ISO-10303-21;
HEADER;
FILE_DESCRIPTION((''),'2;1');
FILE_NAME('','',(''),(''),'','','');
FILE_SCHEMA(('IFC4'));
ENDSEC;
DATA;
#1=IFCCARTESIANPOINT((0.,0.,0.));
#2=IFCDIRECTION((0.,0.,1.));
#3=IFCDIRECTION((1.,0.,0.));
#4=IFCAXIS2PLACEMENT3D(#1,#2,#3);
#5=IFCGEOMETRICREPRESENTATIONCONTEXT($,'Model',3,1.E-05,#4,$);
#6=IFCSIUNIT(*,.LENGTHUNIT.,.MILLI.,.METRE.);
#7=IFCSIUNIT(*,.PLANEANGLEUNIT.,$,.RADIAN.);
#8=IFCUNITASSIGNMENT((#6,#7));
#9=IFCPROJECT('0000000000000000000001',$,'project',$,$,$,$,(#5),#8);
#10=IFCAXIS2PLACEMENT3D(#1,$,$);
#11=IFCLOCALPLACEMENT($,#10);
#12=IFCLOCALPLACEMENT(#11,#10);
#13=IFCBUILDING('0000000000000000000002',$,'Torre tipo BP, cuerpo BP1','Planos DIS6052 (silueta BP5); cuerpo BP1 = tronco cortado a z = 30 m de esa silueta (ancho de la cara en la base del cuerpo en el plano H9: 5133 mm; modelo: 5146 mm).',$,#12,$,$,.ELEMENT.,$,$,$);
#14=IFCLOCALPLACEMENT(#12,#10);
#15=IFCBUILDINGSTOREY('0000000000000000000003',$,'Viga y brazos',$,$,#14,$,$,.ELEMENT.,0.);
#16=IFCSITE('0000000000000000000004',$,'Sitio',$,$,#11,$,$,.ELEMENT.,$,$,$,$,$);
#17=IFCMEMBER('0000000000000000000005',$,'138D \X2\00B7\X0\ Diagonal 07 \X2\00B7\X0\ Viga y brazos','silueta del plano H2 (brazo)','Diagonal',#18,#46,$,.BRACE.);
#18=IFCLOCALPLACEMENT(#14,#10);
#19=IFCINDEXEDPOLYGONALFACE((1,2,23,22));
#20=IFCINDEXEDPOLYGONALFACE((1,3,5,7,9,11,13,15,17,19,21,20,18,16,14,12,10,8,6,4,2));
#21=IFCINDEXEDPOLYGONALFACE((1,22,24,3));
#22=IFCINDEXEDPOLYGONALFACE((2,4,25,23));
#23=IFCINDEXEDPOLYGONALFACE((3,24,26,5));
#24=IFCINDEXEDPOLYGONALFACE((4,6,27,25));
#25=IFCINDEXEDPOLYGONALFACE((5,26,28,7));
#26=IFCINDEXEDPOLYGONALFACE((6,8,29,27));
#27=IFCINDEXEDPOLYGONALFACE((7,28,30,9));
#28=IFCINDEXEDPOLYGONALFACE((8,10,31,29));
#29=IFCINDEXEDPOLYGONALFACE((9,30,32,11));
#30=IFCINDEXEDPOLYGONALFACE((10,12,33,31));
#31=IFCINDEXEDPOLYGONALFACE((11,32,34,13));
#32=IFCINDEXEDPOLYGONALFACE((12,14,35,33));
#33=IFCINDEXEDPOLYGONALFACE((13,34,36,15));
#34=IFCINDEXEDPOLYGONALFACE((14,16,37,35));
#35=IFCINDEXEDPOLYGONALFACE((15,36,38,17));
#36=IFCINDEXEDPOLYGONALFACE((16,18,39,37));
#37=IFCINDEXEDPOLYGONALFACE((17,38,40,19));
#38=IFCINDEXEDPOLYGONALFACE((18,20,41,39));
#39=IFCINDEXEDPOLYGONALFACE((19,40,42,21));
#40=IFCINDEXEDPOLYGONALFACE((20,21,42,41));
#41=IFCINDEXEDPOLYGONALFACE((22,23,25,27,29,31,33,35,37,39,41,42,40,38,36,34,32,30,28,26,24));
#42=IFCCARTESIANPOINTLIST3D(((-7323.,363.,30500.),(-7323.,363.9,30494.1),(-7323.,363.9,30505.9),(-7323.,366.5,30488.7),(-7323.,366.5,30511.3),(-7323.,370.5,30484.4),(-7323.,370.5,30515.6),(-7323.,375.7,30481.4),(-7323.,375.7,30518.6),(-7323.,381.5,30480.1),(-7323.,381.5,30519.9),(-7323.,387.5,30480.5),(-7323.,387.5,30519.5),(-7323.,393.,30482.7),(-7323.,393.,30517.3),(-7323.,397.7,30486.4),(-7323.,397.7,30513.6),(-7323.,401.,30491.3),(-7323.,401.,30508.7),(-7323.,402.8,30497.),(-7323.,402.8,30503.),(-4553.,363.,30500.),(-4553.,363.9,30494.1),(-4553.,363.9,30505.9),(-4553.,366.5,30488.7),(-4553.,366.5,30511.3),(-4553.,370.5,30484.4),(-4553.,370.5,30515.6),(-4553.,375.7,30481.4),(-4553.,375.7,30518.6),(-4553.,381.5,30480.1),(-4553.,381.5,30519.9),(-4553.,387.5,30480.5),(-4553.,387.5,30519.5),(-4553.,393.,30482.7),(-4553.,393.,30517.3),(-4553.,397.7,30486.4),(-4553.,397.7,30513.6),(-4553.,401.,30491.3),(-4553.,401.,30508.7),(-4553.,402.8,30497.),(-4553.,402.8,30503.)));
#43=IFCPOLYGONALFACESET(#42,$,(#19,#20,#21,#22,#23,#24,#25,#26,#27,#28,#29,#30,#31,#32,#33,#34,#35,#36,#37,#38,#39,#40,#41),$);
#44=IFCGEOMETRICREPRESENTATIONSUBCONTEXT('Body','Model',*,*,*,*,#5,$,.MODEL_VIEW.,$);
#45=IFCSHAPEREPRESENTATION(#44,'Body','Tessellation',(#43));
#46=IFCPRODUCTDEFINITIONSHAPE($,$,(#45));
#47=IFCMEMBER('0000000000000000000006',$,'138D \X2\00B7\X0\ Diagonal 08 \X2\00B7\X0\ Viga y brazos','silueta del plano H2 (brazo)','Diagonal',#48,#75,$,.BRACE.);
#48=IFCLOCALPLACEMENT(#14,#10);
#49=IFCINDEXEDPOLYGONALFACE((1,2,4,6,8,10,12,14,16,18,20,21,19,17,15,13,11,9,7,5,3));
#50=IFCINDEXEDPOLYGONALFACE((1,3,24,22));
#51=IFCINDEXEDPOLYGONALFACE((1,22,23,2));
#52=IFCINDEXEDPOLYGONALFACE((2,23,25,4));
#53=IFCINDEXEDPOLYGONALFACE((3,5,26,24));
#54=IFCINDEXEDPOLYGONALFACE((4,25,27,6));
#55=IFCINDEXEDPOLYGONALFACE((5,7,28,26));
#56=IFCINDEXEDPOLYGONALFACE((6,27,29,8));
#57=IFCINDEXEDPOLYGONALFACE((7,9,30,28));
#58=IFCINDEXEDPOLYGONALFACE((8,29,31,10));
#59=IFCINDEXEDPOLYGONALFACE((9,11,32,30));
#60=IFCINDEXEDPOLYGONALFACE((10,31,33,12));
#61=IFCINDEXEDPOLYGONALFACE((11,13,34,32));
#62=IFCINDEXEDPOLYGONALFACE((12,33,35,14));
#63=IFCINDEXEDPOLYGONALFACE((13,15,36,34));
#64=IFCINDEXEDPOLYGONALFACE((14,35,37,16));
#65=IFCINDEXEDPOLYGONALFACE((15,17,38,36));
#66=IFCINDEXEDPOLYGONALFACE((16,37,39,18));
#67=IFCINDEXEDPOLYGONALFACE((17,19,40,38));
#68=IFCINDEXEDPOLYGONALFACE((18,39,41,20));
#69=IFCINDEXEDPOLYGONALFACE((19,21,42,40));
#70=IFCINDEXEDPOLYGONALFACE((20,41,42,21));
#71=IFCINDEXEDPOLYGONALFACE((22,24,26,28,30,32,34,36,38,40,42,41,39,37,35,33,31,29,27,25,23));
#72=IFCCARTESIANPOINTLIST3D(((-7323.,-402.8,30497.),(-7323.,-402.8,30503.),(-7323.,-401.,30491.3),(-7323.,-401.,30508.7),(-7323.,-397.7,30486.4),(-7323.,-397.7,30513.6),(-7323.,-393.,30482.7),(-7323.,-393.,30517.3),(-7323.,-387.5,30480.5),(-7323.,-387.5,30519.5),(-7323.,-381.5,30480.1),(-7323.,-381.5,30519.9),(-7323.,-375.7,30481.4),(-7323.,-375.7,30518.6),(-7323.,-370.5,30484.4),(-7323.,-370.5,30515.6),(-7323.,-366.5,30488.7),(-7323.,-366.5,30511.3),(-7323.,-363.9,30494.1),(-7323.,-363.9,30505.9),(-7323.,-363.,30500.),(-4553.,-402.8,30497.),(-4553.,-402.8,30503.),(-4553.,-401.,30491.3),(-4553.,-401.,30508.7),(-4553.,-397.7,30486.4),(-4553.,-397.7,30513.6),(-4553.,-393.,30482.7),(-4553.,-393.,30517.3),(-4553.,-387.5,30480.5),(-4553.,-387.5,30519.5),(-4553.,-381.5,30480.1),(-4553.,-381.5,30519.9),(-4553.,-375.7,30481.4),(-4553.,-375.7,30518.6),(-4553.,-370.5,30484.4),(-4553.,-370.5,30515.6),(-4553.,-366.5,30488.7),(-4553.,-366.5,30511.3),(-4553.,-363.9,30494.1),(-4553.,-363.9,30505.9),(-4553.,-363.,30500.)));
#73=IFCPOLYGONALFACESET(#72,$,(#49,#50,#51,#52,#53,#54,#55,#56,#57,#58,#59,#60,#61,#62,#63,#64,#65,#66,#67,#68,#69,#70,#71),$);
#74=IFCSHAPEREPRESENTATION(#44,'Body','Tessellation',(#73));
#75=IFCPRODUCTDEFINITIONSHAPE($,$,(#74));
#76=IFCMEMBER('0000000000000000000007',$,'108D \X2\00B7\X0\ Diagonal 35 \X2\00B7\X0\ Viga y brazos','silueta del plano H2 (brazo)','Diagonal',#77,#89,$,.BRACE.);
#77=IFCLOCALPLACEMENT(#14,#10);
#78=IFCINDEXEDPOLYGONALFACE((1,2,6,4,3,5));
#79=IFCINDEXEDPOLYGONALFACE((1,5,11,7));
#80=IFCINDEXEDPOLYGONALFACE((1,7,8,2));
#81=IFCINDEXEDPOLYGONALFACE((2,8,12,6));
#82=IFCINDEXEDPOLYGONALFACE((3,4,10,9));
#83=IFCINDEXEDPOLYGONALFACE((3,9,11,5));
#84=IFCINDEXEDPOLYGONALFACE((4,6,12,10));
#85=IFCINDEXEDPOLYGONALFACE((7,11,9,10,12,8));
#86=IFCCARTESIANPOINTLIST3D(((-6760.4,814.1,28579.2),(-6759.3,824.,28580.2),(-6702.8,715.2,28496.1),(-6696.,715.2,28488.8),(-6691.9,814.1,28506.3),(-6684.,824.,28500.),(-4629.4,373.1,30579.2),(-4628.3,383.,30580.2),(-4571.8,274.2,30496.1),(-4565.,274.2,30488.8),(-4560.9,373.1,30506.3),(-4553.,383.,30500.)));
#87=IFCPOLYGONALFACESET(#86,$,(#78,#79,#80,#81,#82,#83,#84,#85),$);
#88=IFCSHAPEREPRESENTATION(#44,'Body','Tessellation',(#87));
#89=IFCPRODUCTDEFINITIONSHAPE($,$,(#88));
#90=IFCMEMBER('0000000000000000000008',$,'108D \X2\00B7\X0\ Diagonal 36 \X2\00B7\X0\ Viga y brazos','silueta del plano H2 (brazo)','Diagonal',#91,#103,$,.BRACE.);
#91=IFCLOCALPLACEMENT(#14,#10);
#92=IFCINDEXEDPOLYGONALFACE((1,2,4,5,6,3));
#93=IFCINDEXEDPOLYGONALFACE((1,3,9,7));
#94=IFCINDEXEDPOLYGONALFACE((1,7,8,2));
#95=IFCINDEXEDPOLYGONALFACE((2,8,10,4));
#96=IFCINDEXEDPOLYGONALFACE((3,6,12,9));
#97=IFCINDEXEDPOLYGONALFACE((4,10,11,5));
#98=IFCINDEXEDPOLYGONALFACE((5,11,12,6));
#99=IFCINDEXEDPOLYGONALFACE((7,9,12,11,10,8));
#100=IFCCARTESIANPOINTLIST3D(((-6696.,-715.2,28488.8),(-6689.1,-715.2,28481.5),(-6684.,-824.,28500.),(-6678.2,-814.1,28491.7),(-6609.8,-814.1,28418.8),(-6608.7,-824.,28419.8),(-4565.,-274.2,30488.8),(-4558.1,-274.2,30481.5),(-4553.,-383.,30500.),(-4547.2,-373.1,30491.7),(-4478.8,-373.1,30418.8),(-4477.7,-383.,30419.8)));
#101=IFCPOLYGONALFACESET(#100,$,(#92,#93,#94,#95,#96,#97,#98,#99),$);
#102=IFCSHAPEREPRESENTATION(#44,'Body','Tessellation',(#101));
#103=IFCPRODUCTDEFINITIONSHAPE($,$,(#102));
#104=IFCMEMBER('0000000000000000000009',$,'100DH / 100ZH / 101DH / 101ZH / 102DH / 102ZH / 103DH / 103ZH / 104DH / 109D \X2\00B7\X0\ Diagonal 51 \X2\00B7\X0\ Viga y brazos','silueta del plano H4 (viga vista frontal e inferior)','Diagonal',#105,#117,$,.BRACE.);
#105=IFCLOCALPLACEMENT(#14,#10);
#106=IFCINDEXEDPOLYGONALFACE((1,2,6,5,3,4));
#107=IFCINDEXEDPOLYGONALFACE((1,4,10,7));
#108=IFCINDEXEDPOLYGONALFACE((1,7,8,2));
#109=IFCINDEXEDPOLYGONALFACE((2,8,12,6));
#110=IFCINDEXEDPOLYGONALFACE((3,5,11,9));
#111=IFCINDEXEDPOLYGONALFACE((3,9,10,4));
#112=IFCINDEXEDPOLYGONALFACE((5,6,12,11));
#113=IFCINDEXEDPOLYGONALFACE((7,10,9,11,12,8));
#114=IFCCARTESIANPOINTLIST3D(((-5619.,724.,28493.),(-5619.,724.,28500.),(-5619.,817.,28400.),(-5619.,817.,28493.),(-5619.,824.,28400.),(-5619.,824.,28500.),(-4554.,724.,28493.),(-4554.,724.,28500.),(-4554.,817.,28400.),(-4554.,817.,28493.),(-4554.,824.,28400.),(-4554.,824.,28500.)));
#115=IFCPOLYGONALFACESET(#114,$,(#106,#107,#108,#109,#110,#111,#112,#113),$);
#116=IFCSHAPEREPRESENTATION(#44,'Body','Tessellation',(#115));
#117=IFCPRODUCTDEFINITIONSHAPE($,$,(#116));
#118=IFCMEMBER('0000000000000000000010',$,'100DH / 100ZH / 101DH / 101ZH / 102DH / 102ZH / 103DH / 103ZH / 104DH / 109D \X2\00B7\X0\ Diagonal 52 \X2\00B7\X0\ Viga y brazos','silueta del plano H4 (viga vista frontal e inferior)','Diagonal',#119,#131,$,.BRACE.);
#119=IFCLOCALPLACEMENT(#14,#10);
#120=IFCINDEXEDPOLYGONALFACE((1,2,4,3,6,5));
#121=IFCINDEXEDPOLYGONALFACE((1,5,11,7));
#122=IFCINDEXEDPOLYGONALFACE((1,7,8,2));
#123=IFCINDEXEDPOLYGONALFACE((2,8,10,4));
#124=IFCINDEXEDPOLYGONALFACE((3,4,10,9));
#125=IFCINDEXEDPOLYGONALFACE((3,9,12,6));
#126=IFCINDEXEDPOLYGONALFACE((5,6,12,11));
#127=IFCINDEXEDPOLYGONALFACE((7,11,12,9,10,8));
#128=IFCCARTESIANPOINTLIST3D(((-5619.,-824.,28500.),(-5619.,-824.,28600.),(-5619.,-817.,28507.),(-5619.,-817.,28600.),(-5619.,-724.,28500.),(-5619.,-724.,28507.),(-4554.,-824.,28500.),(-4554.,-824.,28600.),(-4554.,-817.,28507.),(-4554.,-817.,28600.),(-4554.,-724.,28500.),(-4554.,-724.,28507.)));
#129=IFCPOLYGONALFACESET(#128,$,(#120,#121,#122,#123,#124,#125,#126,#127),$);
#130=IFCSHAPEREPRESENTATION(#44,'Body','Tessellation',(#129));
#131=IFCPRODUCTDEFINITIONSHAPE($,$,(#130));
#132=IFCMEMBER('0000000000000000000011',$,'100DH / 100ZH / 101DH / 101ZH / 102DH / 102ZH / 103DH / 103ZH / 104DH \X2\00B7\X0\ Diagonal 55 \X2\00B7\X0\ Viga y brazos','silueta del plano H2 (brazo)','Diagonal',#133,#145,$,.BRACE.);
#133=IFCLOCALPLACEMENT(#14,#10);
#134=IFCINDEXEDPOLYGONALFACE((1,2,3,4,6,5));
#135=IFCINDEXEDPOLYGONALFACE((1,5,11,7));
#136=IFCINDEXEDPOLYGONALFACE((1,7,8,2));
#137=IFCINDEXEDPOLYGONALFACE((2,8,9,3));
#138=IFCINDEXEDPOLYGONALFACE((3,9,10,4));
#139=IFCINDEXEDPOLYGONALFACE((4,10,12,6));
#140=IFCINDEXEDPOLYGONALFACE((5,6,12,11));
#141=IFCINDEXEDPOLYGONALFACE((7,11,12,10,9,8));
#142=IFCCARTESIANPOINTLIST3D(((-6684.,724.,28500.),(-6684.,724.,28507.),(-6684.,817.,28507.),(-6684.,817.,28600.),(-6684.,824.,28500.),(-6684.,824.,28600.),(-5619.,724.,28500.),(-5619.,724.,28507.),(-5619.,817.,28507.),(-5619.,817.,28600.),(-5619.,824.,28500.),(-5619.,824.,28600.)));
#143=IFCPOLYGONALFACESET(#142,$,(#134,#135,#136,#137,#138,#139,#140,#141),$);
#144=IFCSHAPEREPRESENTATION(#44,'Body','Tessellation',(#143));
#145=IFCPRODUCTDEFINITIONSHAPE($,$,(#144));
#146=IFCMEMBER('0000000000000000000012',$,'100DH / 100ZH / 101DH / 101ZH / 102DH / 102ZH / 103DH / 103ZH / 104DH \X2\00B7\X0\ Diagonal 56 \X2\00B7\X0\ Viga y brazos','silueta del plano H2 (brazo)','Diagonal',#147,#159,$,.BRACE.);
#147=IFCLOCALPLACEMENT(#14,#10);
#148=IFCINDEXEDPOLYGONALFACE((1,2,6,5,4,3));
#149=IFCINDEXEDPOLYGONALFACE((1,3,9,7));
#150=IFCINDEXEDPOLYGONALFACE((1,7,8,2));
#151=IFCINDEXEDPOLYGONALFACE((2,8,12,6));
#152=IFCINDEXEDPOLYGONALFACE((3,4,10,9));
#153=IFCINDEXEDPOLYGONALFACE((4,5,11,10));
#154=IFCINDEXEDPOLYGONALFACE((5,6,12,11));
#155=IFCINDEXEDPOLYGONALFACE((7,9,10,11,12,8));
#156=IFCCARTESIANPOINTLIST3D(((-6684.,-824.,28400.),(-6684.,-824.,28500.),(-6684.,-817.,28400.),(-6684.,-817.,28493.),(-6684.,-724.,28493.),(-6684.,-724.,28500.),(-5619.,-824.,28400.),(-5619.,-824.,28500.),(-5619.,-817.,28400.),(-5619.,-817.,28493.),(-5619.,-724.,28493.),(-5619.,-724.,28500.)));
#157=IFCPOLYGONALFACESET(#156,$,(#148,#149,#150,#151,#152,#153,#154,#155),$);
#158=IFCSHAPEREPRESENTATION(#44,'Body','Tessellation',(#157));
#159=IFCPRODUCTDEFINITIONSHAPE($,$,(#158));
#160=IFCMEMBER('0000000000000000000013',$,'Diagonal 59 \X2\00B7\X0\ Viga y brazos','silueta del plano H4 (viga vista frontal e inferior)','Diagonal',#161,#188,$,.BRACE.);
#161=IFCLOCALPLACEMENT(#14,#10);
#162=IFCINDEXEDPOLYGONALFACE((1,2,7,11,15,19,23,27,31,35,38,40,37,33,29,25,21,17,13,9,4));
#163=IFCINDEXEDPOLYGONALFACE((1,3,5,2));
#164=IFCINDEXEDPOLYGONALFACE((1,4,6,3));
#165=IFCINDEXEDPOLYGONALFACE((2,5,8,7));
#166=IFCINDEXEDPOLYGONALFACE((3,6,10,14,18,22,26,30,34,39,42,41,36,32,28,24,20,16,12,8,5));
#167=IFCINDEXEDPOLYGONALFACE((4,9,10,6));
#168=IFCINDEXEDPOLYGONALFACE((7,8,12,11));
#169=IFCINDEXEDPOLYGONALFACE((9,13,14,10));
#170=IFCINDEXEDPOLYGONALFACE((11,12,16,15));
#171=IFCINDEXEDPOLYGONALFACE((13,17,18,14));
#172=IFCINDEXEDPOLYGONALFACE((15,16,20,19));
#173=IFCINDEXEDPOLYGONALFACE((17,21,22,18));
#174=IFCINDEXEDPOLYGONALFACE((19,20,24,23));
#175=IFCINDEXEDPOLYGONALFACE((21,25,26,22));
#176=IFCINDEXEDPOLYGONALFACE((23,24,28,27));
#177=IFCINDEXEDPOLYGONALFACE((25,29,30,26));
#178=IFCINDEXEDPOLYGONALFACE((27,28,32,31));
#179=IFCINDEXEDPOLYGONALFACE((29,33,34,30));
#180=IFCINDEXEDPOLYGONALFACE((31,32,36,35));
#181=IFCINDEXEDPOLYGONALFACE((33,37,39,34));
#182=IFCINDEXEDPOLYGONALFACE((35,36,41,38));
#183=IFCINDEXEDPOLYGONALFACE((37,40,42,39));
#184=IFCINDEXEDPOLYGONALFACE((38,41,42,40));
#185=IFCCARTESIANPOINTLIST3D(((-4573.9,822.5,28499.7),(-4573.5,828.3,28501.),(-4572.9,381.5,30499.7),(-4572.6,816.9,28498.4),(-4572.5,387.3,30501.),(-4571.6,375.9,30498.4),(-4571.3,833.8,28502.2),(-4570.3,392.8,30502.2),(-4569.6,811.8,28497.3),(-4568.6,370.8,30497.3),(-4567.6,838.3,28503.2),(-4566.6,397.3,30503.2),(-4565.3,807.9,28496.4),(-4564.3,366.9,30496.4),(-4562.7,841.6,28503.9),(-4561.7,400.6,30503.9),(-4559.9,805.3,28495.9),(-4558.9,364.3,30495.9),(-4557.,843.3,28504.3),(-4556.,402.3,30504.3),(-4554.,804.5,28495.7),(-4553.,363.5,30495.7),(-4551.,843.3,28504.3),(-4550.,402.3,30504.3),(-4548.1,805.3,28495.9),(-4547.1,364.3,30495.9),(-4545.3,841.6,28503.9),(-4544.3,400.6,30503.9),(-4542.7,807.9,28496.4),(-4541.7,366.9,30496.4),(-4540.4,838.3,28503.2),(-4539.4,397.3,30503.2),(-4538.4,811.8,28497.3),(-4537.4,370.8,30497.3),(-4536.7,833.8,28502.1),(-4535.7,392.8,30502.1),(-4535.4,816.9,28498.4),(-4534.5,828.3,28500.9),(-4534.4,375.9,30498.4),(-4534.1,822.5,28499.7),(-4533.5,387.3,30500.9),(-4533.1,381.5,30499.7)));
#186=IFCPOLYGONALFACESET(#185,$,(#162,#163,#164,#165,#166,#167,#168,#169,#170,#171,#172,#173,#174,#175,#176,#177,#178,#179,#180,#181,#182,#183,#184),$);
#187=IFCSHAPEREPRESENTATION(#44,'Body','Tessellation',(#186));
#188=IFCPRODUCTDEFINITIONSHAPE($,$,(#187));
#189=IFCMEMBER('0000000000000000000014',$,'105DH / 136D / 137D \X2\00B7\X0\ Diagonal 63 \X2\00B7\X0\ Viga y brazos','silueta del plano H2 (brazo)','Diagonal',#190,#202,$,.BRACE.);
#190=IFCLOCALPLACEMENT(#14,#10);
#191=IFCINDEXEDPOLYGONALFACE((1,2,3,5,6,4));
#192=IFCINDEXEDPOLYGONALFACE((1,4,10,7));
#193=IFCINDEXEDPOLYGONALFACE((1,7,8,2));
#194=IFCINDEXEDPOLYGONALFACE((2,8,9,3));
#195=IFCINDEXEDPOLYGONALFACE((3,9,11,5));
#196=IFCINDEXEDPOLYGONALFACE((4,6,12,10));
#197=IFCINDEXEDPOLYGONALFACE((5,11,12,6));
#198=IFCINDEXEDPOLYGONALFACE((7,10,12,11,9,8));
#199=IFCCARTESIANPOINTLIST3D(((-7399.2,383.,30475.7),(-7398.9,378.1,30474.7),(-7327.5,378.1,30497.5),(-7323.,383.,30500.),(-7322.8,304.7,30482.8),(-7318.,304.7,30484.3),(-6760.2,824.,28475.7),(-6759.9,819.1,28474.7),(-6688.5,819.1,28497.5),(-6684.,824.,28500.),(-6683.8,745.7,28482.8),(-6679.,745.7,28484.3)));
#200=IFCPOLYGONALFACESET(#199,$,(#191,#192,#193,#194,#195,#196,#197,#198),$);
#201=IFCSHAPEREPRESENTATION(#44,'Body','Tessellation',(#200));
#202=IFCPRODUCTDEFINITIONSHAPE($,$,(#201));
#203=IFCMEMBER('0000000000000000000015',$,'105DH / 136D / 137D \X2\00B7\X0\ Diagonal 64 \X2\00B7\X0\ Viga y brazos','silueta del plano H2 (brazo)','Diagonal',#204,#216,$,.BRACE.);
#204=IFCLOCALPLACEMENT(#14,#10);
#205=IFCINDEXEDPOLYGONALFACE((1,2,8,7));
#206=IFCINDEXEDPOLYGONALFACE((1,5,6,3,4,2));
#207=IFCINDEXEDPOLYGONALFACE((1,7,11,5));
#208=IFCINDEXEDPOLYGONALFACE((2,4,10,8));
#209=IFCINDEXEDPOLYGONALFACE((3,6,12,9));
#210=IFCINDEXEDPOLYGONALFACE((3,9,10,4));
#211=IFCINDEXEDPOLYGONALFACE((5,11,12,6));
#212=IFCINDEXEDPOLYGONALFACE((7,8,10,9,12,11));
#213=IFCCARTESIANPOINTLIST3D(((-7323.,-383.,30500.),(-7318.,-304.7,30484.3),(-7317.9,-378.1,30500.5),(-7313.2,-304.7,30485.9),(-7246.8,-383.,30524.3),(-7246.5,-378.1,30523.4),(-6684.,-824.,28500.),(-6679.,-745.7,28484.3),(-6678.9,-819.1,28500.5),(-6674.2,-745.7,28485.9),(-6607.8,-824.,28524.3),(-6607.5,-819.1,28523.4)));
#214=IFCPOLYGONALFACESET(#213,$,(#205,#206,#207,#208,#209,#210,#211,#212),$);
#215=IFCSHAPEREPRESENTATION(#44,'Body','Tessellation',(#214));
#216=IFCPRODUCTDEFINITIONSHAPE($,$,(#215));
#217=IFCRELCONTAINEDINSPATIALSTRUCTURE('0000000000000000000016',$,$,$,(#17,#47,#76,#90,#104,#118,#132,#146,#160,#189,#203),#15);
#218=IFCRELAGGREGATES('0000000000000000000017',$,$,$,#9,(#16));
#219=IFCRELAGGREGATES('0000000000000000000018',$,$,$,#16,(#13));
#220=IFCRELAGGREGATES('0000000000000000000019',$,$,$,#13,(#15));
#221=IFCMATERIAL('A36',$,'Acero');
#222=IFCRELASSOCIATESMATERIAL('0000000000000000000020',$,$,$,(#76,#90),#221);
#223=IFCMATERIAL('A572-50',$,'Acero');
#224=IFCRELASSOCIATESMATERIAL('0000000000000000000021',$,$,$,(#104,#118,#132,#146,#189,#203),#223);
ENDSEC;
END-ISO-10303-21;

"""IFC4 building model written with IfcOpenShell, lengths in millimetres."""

from ifc_helpers import new_model, si_unit, frame, frame_2d, origin, origin_with_axes, place, context, subcontext, project, spatial, circle, l_section, extrude, material, element, save


model = new_model("IFC4")

# Units and contexts
model_context = context("Model", 3, precision=1e-05, world=origin_with_axes())
body_context = subcontext(model_context, "Body", "Model", "MODEL_VIEW")
ifc_project = project(units=[si_unit("LENGTHUNIT", "METRE", prefix="MILLI"), si_unit("PLANEANGLEUNIT", "RADIAN")], contexts=[model_context])

# Site, building, storey
site_placement = place(None, origin())
site = spatial("IfcSite", under=ifc_project, at=site_placement, Name="Sitio", CompositionType="ELEMENT")
building_placement = place(site_placement, origin())
building = spatial("IfcBuilding", under=site, at=building_placement, Name="Torre tipo BP, cuerpo BP1", Description="Planos DIS6052 (silueta BP5); cuerpo BP1 = tronco cortado a z = 30 m de esa silueta (ancho de la cara en la base del cuerpo en el plano H9: 5133 mm; modelo: 5146 mm).", CompositionType="ELEMENT")
storey_placement = place(building_placement, origin())
storey = spatial("IfcBuildingStorey", under=building, at=storey_placement, Name="Viga y brazos", CompositionType="ELEMENT", Elevation=0.0)

# Members
for number, where, z_axis, x_axis, name in (
    (1, (-7323.0, 383.0, 30500.0), (1.0, 0.0, 0.0), (0.0, -1.0, 0.0), "138D · Diagonal 07 · Viga y brazos"),
    (2, (-7323.0, -383.0, 30500.0), (1.0, 0.0, 0.0), (0.0, 1.0, 0.0), "138D · Diagonal 08 · Viga y brazos"),
):
    element("IfcMember", number, at=place(storey_placement, frame(where, z_axis=z_axis, x_axis=x_axis)), inside=storey, Name=name, Description="silueta del plano H2 (brazo)", ObjectType="Diagonal", PredefinedType="BRACE", context=body_context, shape_type="SweptSolid", body=[
        extrude(circle(Radius=20.0), None, (0.0, 0.0, 1.0), 2770.0),
    ])
ifc_material_1 = material(Name="A36", Category="Acero")
for number, where, z_axis, x_axis, name in (
    (3, (-4553.0, 383.0, 30500.0), (-0.721001, 0.149208, -0.676679), (-0.108797, -0.988806, -0.102109), "108D · Diagonal 35 · Viga y brazos"),
    (4, (-4553.0, -383.0, 30500.0), (-0.721001, -0.149208, -0.676679), (-0.108797, 0.988806, -0.102109), "108D · Diagonal 36 · Viga y brazos"),
):
    element("IfcMember", number, at=place(storey_placement, frame(where, z_axis=z_axis, x_axis=x_axis)), inside=storey, material=ifc_material_1, Name=name, Description="silueta del plano H2 (brazo)", ObjectType="Diagonal", PredefinedType="BRACE", context=body_context, shape_type="SweptSolid", body=[
        extrude(l_section(Depth=110.0, Width=110.0, Thickness=10.0, at=frame_2d((55.0, 55.0))), None, (0.0, 0.0, 1.0), 2955.6),
    ])
ifc_material_2 = material(Name="A572-50", Category="Acero")
for number, where, z_axis, x_axis, name, description in (
    (5, (-5619.0, 824.0, 28500.0), (1.0, 0.0, 0.0), (0.0, -1.0, 0.0), "100DH / 100ZH / 101DH / 101ZH / 102DH / 102ZH / 103DH / 103ZH / 104DH / 109D · Diagonal 51 · Viga y brazos", "silueta del plano H4 (viga vista frontal e inferior)"),
    (6, (-5619.0, -824.0, 28500.0), (1.0, 0.0, 0.0), (0.0, 1.0, 0.0), "100DH / 100ZH / 101DH / 101ZH / 102DH / 102ZH / 103DH / 103ZH / 104DH / 109D · Diagonal 52 · Viga y brazos", "silueta del plano H4 (viga vista frontal e inferior)"),
    (7, (-5619.0, 824.0, 28500.0), (-1.0, 0.0, 0.0), (0.0, -1.0, 0.0), "100DH / 100ZH / 101DH / 101ZH / 102DH / 102ZH / 103DH / 103ZH / 104DH · Diagonal 55 · Viga y brazos", "silueta del plano H2 (brazo)"),
    (8, (-5619.0, -824.0, 28500.0), (-1.0, 0.0, 0.0), (0.0, 1.0, 0.0), "100DH / 100ZH / 101DH / 101ZH / 102DH / 102ZH / 103DH / 103ZH / 104DH · Diagonal 56 · Viga y brazos", "silueta del plano H2 (brazo)"),
):
    element("IfcMember", number, at=place(storey_placement, frame(where, z_axis=z_axis, x_axis=x_axis)), inside=storey, material=ifc_material_2, Name=name, Description=description, ObjectType="Diagonal", PredefinedType="BRACE", context=body_context, shape_type="SweptSolid", body=[
        extrude(l_section(Depth=100.0, Width=100.0, Thickness=7.0, at=frame_2d((50.0, 50.0))), None, (0.0, 0.0, 1.0), 1065.0),
    ])
member_placement = place(storey_placement, frame((-4553.0, 383.0, 30500.0), z_axis=(-0.000488, 0.215327, -0.976542), x_axis=(-0.000108, -0.976542, -0.215327)))
element("IfcMember", 9, at=member_placement, inside=storey, Name="Diagonal 59 · Viga y brazos", Description="silueta del plano H4 (viga vista frontal e inferior)", ObjectType="Diagonal", PredefinedType="BRACE", context=body_context, shape_type="SweptSolid", body=[
    extrude(circle(Radius=20.0), None, (0.0, 0.0, 1.0), 2048.0),
])
for number, where, z_axis, x_axis, name in (
    (10, (-7323.0, 383.0, 30500.0), (0.297845, 0.205555, -0.932221), (0.062559, -0.978646, -0.195804), "105DH / 136D / 137D · Diagonal 63 · Viga y brazos"),
    (11, (-7323.0, -383.0, 30500.0), (0.297845, -0.205555, -0.932221), (0.062559, 0.978646, -0.195804), "105DH / 136D / 137D · Diagonal 64 · Viga y brazos"),
):
    element("IfcMember", number, at=place(storey_placement, frame(where, z_axis=z_axis, x_axis=x_axis)), inside=storey, material=ifc_material_2, Name=name, Description="silueta del plano H2 (brazo)", ObjectType="Diagonal", PredefinedType="BRACE", context=body_context, shape_type="SweptSolid", body=[
        extrude(l_section(Depth=80.0, Width=80.0, Thickness=5.0, at=frame_2d((40.0, 40.0))), None, (0.0, 0.0, 1.0), 2145.4),
    ])

save(model, "model.ifc")
